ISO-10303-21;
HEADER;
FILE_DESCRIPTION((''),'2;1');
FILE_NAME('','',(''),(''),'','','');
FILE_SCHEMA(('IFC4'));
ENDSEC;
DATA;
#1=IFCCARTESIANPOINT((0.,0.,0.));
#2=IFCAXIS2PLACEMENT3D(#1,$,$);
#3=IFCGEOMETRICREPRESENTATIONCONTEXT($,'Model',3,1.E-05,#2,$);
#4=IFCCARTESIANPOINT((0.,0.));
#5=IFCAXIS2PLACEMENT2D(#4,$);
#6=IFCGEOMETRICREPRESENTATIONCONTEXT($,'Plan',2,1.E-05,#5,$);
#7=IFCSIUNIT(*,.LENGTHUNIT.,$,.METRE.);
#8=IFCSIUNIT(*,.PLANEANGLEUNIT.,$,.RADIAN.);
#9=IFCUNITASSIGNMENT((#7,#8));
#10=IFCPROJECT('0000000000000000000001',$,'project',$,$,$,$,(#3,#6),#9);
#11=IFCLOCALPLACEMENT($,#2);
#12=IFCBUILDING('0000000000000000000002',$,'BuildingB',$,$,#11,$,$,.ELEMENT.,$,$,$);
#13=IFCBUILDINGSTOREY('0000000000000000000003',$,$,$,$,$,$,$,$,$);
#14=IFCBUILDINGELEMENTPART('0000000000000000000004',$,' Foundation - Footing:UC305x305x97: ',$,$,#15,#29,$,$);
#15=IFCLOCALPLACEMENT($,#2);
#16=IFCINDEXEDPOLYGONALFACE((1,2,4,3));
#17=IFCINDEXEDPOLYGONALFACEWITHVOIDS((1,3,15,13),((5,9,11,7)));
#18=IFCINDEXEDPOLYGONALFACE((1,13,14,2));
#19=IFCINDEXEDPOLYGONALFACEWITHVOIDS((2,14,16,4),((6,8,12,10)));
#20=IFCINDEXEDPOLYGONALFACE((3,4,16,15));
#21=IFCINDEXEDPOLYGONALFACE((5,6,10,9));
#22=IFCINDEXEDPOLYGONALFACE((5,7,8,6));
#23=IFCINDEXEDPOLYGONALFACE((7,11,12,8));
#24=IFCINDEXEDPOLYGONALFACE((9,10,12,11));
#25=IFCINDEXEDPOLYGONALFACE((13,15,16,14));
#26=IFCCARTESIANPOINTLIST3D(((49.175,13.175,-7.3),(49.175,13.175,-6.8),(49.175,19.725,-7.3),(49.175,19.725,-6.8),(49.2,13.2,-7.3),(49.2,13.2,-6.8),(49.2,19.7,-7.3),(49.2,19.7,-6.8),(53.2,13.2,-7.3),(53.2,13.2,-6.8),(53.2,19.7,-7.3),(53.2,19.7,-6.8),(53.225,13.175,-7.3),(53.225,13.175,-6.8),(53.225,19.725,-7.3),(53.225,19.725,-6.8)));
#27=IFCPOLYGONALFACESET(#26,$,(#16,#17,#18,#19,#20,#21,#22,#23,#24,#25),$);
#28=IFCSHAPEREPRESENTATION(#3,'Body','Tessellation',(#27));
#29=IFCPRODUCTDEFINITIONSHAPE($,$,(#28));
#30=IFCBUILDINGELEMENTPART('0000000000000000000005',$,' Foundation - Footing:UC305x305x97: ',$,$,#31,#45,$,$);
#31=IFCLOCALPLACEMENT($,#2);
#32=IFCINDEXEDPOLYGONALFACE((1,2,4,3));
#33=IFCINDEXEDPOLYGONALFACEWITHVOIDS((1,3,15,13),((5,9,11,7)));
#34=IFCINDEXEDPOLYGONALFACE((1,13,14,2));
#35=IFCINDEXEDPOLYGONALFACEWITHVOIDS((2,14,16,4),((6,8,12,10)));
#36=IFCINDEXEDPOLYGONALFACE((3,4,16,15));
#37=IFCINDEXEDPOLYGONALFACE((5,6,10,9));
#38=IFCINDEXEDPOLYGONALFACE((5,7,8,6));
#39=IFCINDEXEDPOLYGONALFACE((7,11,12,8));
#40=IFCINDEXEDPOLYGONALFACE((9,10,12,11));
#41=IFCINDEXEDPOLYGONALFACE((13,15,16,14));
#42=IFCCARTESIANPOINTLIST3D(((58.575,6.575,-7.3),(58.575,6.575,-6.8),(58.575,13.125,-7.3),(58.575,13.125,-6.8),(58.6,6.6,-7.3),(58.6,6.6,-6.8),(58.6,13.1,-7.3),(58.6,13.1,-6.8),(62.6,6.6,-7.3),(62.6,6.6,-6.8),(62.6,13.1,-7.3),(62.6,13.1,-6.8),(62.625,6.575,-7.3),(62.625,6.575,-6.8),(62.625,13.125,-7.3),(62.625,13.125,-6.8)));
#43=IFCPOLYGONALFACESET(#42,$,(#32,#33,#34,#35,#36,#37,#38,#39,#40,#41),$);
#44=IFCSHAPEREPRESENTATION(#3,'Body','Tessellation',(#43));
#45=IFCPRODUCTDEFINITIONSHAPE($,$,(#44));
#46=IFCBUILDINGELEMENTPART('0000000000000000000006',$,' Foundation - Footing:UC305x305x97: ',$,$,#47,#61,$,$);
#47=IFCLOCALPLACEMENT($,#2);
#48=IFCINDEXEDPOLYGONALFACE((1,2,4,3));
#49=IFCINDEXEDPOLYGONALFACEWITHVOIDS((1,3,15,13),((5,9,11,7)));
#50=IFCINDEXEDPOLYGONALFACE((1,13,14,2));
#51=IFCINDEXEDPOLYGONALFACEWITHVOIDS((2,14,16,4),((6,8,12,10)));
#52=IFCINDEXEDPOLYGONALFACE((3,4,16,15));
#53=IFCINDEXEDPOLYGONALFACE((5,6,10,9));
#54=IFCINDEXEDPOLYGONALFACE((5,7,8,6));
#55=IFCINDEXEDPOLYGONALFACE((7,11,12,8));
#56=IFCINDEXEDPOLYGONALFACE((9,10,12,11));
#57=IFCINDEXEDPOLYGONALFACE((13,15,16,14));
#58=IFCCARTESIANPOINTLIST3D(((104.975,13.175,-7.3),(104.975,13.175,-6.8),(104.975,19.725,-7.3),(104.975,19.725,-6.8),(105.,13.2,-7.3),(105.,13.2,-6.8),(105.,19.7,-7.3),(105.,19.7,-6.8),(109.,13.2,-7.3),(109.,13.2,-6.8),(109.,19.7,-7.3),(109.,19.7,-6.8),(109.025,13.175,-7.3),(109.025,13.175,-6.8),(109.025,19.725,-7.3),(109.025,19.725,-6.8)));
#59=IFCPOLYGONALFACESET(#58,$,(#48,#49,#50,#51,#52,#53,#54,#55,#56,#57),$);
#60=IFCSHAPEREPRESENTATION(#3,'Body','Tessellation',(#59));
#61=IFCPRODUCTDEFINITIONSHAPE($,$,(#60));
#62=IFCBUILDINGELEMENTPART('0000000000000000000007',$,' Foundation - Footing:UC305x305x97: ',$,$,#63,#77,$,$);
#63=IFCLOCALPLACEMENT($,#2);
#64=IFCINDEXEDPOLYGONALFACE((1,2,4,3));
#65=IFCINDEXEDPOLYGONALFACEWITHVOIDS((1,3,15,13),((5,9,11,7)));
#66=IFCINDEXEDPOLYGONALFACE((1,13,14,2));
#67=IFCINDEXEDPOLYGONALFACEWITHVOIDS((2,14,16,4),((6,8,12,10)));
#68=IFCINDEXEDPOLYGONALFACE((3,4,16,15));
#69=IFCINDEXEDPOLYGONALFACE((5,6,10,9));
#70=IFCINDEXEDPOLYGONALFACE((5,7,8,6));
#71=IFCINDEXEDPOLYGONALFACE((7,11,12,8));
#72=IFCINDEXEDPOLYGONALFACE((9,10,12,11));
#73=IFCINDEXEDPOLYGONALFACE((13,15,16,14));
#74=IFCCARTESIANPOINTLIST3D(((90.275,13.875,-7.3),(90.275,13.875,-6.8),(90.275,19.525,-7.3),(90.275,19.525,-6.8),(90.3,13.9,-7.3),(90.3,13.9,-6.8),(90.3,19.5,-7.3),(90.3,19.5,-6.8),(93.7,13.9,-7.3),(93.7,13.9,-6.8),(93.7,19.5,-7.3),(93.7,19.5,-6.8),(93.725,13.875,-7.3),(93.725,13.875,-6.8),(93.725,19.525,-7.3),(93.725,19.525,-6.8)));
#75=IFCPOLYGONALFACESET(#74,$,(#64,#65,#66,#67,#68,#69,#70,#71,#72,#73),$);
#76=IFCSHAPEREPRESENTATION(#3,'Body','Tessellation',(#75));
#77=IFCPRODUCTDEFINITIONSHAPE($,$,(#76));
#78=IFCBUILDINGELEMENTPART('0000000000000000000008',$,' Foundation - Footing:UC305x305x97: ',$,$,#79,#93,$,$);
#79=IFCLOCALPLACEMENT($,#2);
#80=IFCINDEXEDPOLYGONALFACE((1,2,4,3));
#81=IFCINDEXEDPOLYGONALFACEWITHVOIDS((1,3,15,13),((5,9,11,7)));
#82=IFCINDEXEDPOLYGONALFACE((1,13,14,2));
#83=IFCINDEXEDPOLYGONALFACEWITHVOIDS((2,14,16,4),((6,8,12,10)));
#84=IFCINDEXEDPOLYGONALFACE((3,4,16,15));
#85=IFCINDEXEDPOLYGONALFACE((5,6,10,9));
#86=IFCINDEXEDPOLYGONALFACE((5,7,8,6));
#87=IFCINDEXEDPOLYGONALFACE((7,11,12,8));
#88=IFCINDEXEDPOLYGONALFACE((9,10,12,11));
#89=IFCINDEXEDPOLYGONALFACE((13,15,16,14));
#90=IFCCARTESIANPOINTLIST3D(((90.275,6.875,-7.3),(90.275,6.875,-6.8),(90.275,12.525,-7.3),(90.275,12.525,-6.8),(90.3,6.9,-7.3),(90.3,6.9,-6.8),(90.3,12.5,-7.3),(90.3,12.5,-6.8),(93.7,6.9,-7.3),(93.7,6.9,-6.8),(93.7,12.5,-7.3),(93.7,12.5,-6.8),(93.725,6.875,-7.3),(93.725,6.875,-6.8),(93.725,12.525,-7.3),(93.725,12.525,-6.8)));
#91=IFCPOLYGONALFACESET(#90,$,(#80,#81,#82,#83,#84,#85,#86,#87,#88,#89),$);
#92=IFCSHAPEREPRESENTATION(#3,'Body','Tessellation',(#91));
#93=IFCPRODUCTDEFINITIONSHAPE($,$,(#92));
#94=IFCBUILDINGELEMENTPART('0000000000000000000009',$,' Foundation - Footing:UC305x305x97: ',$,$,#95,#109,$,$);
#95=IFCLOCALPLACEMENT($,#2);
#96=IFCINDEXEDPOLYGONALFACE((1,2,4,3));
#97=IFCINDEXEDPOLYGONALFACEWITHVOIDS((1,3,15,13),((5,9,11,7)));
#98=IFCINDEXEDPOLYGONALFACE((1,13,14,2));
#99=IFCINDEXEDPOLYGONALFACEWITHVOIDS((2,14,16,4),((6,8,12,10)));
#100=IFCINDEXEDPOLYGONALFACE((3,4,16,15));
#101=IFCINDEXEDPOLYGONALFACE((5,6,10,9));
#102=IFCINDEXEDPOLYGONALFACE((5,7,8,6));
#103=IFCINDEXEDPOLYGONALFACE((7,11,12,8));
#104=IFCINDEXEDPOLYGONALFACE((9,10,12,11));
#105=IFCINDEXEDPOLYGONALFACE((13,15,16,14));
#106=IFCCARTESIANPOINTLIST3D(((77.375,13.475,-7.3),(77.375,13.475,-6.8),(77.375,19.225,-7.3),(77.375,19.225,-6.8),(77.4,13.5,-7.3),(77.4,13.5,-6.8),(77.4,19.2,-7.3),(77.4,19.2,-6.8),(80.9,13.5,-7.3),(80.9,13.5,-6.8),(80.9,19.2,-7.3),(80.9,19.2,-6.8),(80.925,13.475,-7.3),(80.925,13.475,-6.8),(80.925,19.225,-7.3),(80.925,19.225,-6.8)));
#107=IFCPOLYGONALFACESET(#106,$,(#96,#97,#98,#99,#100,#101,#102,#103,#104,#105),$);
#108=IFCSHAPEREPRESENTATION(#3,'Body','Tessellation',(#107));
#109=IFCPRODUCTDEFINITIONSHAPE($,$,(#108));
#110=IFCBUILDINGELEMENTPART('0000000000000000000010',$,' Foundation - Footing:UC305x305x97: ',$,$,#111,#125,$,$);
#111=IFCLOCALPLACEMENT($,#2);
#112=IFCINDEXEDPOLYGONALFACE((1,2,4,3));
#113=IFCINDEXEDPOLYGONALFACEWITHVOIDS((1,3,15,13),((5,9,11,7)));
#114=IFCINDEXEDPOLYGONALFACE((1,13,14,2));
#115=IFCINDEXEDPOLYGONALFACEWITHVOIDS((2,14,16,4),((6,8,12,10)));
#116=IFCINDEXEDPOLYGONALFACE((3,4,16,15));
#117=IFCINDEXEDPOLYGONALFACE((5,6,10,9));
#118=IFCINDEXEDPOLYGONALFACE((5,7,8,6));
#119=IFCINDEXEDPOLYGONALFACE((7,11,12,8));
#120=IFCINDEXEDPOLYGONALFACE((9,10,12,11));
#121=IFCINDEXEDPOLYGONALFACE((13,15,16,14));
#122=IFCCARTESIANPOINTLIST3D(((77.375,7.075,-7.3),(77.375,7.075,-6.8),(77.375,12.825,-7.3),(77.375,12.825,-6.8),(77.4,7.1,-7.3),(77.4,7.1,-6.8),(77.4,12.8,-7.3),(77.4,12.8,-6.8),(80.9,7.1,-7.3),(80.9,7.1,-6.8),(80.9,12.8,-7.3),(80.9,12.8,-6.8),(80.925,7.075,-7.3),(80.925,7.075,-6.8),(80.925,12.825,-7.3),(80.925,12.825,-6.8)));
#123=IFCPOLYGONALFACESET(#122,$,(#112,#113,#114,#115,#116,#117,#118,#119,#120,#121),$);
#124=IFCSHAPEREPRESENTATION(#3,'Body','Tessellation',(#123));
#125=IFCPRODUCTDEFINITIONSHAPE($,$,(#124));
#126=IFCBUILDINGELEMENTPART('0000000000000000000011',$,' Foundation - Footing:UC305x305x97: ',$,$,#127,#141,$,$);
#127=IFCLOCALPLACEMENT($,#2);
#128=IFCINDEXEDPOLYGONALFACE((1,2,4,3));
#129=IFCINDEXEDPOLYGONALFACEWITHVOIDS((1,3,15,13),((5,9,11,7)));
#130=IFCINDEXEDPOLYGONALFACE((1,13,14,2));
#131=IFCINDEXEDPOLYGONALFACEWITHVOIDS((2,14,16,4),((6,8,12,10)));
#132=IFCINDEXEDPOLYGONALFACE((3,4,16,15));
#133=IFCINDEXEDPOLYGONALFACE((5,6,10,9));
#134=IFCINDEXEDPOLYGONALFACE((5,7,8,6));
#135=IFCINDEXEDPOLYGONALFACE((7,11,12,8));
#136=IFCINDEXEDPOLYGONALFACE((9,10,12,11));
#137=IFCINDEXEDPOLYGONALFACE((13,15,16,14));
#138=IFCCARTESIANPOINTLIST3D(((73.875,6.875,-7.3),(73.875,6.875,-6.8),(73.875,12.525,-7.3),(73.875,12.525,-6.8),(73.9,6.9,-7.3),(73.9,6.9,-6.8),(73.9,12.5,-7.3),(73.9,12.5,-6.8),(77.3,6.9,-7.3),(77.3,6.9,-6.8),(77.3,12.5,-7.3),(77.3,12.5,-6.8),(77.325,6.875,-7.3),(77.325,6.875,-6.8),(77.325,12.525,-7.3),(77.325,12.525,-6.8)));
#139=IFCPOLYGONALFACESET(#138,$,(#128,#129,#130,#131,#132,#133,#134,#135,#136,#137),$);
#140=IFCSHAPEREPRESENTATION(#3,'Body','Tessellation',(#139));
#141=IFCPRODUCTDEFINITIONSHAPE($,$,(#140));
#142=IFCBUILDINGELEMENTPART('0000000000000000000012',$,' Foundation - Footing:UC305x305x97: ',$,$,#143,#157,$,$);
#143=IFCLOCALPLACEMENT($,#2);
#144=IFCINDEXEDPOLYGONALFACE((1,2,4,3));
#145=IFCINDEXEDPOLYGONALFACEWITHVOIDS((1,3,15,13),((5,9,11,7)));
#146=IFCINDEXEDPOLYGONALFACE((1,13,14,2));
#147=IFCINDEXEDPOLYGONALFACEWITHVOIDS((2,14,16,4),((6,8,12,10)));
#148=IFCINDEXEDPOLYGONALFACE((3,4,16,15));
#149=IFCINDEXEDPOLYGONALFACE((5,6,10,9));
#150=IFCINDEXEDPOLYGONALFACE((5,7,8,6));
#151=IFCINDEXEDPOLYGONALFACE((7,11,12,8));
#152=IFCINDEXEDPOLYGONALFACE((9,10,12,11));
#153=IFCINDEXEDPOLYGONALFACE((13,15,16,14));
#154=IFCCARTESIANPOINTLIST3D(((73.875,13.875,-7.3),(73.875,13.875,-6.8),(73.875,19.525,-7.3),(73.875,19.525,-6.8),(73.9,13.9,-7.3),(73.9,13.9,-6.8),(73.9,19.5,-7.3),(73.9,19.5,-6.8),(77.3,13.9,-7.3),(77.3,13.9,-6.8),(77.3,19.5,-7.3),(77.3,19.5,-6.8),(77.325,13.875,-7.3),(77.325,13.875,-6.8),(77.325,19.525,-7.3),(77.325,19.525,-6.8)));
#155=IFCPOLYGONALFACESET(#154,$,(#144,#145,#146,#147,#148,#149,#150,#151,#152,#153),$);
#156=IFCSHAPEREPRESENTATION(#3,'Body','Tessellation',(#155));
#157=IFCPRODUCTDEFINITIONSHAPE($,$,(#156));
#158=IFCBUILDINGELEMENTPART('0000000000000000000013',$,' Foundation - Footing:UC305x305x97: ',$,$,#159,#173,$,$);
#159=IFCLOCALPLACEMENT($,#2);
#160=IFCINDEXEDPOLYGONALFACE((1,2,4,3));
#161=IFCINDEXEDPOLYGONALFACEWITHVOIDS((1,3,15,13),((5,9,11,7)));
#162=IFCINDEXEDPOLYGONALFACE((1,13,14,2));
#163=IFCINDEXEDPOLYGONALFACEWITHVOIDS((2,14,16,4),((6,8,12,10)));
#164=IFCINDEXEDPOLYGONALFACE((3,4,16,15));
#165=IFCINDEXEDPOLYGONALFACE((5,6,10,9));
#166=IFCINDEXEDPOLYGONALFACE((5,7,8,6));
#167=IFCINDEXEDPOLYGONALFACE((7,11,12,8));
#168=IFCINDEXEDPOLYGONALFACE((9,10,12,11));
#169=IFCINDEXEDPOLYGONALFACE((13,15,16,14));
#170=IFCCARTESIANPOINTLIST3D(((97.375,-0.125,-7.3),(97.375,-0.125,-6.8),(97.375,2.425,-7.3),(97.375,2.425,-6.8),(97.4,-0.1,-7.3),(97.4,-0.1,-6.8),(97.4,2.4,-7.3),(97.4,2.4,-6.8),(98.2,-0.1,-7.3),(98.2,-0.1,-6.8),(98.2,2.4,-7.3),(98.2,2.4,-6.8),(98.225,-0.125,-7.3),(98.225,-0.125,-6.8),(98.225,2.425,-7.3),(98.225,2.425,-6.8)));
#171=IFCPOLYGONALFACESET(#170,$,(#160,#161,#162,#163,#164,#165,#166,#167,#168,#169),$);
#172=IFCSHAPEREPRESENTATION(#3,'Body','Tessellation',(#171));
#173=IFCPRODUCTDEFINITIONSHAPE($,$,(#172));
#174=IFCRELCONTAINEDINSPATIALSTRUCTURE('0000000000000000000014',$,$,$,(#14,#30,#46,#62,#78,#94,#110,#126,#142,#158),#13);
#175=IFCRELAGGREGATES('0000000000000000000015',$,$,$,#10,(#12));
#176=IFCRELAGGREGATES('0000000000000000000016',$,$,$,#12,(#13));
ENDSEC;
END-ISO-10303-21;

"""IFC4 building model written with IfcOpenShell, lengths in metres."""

from ifc_helpers import new_model, si_unit, origin, origin_2d, place, context, project, spatial, polyline, outline, extrude, element, save


model = new_model("IFC4")

# Units and contexts
model_context = context("Model", 3, precision=1e-05, world=origin())
plan_context = context("Plan", 2, precision=1e-05, world=origin_2d())
ifc_project = project(units=[si_unit("LENGTHUNIT", "METRE"), si_unit("PLANEANGLEUNIT", "RADIAN")], contexts=[model_context, plan_context])

# Building, storey
building_placement = place(None, origin())
building = spatial("IfcBuilding", under=ifc_project, at=building_placement, Name="BuildingB", CompositionType="ELEMENT")
storey = spatial("IfcBuildingStorey", under=building)

# Building element parts, openings
building_element_part_1 = element("IfcBuildingElementPart", 1, inside=storey, Name=" Foundation - Footing:UC305x305x97: ", context=model_context, shape_type="SweptSolid", body=[
    extrude(outline(polyline([(53.225, 19.725, -7.3), (49.175, 19.725, -7.3), (49.175, 13.175, -7.3), (53.225, 13.175, -7.3), (53.225, 19.725, -7.3)])), None, (0.0, 0.0, 1.0), 0.5),
])
element("IfcOpeningElement", 2, inside=storey, cuts=building_element_part_1, context=model_context, shape_type="SweptSolid", body=[
    extrude(outline(polyline([(53.2, 19.7, -7.3), (49.2, 19.7, -7.3), (49.2, 13.2, -7.3), (53.2, 13.2, -7.3), (53.2, 19.7, -7.3)])), None, (0.0, 0.0, 1.0), 0.5),
])
building_element_part_2 = element("IfcBuildingElementPart", 3, inside=storey, Name=" Foundation - Footing:UC305x305x97: ", context=model_context, shape_type="SweptSolid", body=[
    extrude(outline(polyline([(58.575, 13.125, -7.3), (62.625, 13.125, -7.3), (62.625, 6.575, -7.3), (58.575, 6.575, -7.3), (58.575, 13.125, -7.3)])), None, (0.0, 0.0, 1.0), 0.5),
])
element("IfcOpeningElement", 4, inside=storey, cuts=building_element_part_2, context=model_context, shape_type="SweptSolid", body=[
    extrude(outline(polyline([(58.6, 13.1, -7.3), (62.6, 13.1, -7.3), (62.6, 6.6, -7.3), (58.6, 6.6, -7.3), (58.6, 13.1, -7.3)])), None, (0.0, 0.0, 1.0), 0.5),
])
building_element_part_3 = element("IfcBuildingElementPart", 5, inside=storey, Name=" Foundation - Footing:UC305x305x97: ", context=model_context, shape_type="SweptSolid", body=[
    extrude(outline(polyline([(109.025, 19.725, -7.3), (104.975, 19.725, -7.3), (104.975, 13.175, -7.3), (109.025, 13.175, -7.3), (109.025, 19.725, -7.3)])), None, (0.0, 0.0, 1.0), 0.5),
])
element("IfcOpeningElement", 6, inside=storey, cuts=building_element_part_3, context=model_context, shape_type="SweptSolid", body=[
    extrude(outline(polyline([(109.0, 19.7, -7.3), (105.0, 19.7, -7.3), (105.0, 13.2, -7.3), (109.0, 13.2, -7.3), (109.0, 19.7, -7.3)])), None, (0.0, 0.0, 1.0), 0.5),
])
building_element_part_4 = element("IfcBuildingElementPart", 7, inside=storey, Name=" Foundation - Footing:UC305x305x97: ", context=model_context, shape_type="SweptSolid", body=[
    extrude(outline(polyline([(90.275, 19.525, -7.3), (93.725, 19.525, -7.3), (93.725, 13.875, -7.3), (90.275, 13.875, -7.3), (90.275, 19.525, -7.3)])), None, (0.0, 0.0, 1.0), 0.5),
])
element("IfcOpeningElement", 8, inside=storey, cuts=building_element_part_4, context=model_context, shape_type="SweptSolid", body=[
    extrude(outline(polyline([(90.3, 19.5, -7.3), (93.7, 19.5, -7.3), (93.7, 13.9, -7.3), (90.3, 13.9, -7.3), (90.3, 19.5, -7.3)])), None, (0.0, 0.0, 1.0), 0.5),
])
building_element_part_5 = element("IfcBuildingElementPart", 9, inside=storey, Name=" Foundation - Footing:UC305x305x97: ", context=model_context, shape_type="SweptSolid", body=[
    extrude(outline(polyline([(90.275, 12.525, -7.3), (93.725, 12.525, -7.3), (93.725, 6.875, -7.3), (90.275, 6.875, -7.3), (90.275, 12.525, -7.3)])), None, (0.0, 0.0, 1.0), 0.5),
])
element("IfcOpeningElement", 10, inside=storey, cuts=building_element_part_5, context=model_context, shape_type="SweptSolid", body=[
    extrude(outline(polyline([(90.3, 12.5, -7.3), (93.7, 12.5, -7.3), (93.7, 6.9, -7.3), (90.3, 6.9, -7.3), (90.3, 12.5, -7.3)])), None, (0.0, 0.0, 1.0), 0.5),
])
building_element_part_6 = element("IfcBuildingElementPart", 11, inside=storey, Name=" Foundation - Footing:UC305x305x97: ", context=model_context, shape_type="SweptSolid", body=[
    extrude(outline(polyline([(77.375, 19.225, -7.3), (80.925, 19.225, -7.3), (80.925, 13.475, -7.3), (77.375, 13.475, -7.3), (77.375, 19.225, -7.3)])), None, (0.0, 0.0, 1.0), 0.5),
])
element("IfcOpeningElement", 12, inside=storey, cuts=building_element_part_6, context=model_context, shape_type="SweptSolid", body=[
    extrude(outline(polyline([(77.4, 19.2, -7.3), (80.9, 19.2, -7.3), (80.9, 13.5, -7.3), (77.4, 13.5, -7.3), (77.4, 19.2, -7.3)])), None, (0.0, 0.0, 1.0), 0.5),
])
building_element_part_7 = element("IfcBuildingElementPart", 13, inside=storey, Name=" Foundation - Footing:UC305x305x97: ", context=model_context, shape_type="SweptSolid", body=[
    extrude(outline(polyline([(77.375, 12.825, -7.3), (80.925, 12.825, -7.3), (80.925, 7.075, -7.3), (77.375, 7.075, -7.3), (77.375, 12.825, -7.3)])), None, (0.0, 0.0, 1.0), 0.5),
])
element("IfcOpeningElement", 14, inside=storey, cuts=building_element_part_7, context=model_context, shape_type="SweptSolid", body=[
    extrude(outline(polyline([(77.4, 12.8, -7.3), (80.9, 12.8, -7.3), (80.9, 7.1, -7.3), (77.4, 7.1, -7.3), (77.4, 12.8, -7.3)])), None, (0.0, 0.0, 1.0), 0.5),
])
building_element_part_8 = element("IfcBuildingElementPart", 15, inside=storey, Name=" Foundation - Footing:UC305x305x97: ", context=model_context, shape_type="SweptSolid", body=[
    extrude(outline(polyline([(73.875, 12.525, -7.3), (77.325, 12.525, -7.3), (77.325, 6.875, -7.3), (73.875, 6.875, -7.3), (73.875, 12.525, -7.3)])), None, (0.0, 0.0, 1.0), 0.5),
])
element("IfcOpeningElement", 16, inside=storey, cuts=building_element_part_8, context=model_context, shape_type="SweptSolid", body=[
    extrude(outline(polyline([(73.9, 12.5, -7.3), (77.3, 12.5, -7.3), (77.3, 6.9, -7.3), (73.9, 6.9, -7.3), (73.9, 12.5, -7.3)])), None, (0.0, 0.0, 1.0), 0.5),
])
building_element_part_9 = element("IfcBuildingElementPart", 17, inside=storey, Name=" Foundation - Footing:UC305x305x97: ", context=model_context, shape_type="SweptSolid", body=[
    extrude(outline(polyline([(73.875, 19.525, -7.3), (77.325, 19.525, -7.3), (77.325, 13.875, -7.3), (73.875, 13.875, -7.3), (73.875, 19.525, -7.3)])), None, (0.0, 0.0, 1.0), 0.5),
])
element("IfcOpeningElement", 18, inside=storey, cuts=building_element_part_9, context=model_context, shape_type="SweptSolid", body=[
    extrude(outline(polyline([(73.9, 19.5, -7.3), (77.3, 19.5, -7.3), (77.3, 13.9, -7.3), (73.9, 13.9, -7.3), (73.9, 19.5, -7.3)])), None, (0.0, 0.0, 1.0), 0.5),
])
building_element_part_10 = element("IfcBuildingElementPart", 19, inside=storey, Name=" Foundation - Footing:UC305x305x97: ", context=model_context, shape_type="SweptSolid", body=[
    extrude(outline(polyline([(97.375, 2.425, -7.3), (98.225, 2.425, -7.3), (98.225, -0.125, -7.3), (97.375, -0.125, -7.3), (97.375, 2.425, -7.3)])), None, (0.0, 0.0, 1.0), 0.5),
])
element("IfcOpeningElement", 20, inside=storey, cuts=building_element_part_10, context=model_context, shape_type="SweptSolid", body=[
    extrude(outline(polyline([(97.4, 2.4, -7.3), (98.2, 2.4, -7.3), (98.2, -0.1, -7.3), (97.4, -0.1, -7.3), (97.4, 2.4, -7.3)])), None, (0.0, 0.0, 1.0), 0.5),
])

save(model, "model.ifc")
